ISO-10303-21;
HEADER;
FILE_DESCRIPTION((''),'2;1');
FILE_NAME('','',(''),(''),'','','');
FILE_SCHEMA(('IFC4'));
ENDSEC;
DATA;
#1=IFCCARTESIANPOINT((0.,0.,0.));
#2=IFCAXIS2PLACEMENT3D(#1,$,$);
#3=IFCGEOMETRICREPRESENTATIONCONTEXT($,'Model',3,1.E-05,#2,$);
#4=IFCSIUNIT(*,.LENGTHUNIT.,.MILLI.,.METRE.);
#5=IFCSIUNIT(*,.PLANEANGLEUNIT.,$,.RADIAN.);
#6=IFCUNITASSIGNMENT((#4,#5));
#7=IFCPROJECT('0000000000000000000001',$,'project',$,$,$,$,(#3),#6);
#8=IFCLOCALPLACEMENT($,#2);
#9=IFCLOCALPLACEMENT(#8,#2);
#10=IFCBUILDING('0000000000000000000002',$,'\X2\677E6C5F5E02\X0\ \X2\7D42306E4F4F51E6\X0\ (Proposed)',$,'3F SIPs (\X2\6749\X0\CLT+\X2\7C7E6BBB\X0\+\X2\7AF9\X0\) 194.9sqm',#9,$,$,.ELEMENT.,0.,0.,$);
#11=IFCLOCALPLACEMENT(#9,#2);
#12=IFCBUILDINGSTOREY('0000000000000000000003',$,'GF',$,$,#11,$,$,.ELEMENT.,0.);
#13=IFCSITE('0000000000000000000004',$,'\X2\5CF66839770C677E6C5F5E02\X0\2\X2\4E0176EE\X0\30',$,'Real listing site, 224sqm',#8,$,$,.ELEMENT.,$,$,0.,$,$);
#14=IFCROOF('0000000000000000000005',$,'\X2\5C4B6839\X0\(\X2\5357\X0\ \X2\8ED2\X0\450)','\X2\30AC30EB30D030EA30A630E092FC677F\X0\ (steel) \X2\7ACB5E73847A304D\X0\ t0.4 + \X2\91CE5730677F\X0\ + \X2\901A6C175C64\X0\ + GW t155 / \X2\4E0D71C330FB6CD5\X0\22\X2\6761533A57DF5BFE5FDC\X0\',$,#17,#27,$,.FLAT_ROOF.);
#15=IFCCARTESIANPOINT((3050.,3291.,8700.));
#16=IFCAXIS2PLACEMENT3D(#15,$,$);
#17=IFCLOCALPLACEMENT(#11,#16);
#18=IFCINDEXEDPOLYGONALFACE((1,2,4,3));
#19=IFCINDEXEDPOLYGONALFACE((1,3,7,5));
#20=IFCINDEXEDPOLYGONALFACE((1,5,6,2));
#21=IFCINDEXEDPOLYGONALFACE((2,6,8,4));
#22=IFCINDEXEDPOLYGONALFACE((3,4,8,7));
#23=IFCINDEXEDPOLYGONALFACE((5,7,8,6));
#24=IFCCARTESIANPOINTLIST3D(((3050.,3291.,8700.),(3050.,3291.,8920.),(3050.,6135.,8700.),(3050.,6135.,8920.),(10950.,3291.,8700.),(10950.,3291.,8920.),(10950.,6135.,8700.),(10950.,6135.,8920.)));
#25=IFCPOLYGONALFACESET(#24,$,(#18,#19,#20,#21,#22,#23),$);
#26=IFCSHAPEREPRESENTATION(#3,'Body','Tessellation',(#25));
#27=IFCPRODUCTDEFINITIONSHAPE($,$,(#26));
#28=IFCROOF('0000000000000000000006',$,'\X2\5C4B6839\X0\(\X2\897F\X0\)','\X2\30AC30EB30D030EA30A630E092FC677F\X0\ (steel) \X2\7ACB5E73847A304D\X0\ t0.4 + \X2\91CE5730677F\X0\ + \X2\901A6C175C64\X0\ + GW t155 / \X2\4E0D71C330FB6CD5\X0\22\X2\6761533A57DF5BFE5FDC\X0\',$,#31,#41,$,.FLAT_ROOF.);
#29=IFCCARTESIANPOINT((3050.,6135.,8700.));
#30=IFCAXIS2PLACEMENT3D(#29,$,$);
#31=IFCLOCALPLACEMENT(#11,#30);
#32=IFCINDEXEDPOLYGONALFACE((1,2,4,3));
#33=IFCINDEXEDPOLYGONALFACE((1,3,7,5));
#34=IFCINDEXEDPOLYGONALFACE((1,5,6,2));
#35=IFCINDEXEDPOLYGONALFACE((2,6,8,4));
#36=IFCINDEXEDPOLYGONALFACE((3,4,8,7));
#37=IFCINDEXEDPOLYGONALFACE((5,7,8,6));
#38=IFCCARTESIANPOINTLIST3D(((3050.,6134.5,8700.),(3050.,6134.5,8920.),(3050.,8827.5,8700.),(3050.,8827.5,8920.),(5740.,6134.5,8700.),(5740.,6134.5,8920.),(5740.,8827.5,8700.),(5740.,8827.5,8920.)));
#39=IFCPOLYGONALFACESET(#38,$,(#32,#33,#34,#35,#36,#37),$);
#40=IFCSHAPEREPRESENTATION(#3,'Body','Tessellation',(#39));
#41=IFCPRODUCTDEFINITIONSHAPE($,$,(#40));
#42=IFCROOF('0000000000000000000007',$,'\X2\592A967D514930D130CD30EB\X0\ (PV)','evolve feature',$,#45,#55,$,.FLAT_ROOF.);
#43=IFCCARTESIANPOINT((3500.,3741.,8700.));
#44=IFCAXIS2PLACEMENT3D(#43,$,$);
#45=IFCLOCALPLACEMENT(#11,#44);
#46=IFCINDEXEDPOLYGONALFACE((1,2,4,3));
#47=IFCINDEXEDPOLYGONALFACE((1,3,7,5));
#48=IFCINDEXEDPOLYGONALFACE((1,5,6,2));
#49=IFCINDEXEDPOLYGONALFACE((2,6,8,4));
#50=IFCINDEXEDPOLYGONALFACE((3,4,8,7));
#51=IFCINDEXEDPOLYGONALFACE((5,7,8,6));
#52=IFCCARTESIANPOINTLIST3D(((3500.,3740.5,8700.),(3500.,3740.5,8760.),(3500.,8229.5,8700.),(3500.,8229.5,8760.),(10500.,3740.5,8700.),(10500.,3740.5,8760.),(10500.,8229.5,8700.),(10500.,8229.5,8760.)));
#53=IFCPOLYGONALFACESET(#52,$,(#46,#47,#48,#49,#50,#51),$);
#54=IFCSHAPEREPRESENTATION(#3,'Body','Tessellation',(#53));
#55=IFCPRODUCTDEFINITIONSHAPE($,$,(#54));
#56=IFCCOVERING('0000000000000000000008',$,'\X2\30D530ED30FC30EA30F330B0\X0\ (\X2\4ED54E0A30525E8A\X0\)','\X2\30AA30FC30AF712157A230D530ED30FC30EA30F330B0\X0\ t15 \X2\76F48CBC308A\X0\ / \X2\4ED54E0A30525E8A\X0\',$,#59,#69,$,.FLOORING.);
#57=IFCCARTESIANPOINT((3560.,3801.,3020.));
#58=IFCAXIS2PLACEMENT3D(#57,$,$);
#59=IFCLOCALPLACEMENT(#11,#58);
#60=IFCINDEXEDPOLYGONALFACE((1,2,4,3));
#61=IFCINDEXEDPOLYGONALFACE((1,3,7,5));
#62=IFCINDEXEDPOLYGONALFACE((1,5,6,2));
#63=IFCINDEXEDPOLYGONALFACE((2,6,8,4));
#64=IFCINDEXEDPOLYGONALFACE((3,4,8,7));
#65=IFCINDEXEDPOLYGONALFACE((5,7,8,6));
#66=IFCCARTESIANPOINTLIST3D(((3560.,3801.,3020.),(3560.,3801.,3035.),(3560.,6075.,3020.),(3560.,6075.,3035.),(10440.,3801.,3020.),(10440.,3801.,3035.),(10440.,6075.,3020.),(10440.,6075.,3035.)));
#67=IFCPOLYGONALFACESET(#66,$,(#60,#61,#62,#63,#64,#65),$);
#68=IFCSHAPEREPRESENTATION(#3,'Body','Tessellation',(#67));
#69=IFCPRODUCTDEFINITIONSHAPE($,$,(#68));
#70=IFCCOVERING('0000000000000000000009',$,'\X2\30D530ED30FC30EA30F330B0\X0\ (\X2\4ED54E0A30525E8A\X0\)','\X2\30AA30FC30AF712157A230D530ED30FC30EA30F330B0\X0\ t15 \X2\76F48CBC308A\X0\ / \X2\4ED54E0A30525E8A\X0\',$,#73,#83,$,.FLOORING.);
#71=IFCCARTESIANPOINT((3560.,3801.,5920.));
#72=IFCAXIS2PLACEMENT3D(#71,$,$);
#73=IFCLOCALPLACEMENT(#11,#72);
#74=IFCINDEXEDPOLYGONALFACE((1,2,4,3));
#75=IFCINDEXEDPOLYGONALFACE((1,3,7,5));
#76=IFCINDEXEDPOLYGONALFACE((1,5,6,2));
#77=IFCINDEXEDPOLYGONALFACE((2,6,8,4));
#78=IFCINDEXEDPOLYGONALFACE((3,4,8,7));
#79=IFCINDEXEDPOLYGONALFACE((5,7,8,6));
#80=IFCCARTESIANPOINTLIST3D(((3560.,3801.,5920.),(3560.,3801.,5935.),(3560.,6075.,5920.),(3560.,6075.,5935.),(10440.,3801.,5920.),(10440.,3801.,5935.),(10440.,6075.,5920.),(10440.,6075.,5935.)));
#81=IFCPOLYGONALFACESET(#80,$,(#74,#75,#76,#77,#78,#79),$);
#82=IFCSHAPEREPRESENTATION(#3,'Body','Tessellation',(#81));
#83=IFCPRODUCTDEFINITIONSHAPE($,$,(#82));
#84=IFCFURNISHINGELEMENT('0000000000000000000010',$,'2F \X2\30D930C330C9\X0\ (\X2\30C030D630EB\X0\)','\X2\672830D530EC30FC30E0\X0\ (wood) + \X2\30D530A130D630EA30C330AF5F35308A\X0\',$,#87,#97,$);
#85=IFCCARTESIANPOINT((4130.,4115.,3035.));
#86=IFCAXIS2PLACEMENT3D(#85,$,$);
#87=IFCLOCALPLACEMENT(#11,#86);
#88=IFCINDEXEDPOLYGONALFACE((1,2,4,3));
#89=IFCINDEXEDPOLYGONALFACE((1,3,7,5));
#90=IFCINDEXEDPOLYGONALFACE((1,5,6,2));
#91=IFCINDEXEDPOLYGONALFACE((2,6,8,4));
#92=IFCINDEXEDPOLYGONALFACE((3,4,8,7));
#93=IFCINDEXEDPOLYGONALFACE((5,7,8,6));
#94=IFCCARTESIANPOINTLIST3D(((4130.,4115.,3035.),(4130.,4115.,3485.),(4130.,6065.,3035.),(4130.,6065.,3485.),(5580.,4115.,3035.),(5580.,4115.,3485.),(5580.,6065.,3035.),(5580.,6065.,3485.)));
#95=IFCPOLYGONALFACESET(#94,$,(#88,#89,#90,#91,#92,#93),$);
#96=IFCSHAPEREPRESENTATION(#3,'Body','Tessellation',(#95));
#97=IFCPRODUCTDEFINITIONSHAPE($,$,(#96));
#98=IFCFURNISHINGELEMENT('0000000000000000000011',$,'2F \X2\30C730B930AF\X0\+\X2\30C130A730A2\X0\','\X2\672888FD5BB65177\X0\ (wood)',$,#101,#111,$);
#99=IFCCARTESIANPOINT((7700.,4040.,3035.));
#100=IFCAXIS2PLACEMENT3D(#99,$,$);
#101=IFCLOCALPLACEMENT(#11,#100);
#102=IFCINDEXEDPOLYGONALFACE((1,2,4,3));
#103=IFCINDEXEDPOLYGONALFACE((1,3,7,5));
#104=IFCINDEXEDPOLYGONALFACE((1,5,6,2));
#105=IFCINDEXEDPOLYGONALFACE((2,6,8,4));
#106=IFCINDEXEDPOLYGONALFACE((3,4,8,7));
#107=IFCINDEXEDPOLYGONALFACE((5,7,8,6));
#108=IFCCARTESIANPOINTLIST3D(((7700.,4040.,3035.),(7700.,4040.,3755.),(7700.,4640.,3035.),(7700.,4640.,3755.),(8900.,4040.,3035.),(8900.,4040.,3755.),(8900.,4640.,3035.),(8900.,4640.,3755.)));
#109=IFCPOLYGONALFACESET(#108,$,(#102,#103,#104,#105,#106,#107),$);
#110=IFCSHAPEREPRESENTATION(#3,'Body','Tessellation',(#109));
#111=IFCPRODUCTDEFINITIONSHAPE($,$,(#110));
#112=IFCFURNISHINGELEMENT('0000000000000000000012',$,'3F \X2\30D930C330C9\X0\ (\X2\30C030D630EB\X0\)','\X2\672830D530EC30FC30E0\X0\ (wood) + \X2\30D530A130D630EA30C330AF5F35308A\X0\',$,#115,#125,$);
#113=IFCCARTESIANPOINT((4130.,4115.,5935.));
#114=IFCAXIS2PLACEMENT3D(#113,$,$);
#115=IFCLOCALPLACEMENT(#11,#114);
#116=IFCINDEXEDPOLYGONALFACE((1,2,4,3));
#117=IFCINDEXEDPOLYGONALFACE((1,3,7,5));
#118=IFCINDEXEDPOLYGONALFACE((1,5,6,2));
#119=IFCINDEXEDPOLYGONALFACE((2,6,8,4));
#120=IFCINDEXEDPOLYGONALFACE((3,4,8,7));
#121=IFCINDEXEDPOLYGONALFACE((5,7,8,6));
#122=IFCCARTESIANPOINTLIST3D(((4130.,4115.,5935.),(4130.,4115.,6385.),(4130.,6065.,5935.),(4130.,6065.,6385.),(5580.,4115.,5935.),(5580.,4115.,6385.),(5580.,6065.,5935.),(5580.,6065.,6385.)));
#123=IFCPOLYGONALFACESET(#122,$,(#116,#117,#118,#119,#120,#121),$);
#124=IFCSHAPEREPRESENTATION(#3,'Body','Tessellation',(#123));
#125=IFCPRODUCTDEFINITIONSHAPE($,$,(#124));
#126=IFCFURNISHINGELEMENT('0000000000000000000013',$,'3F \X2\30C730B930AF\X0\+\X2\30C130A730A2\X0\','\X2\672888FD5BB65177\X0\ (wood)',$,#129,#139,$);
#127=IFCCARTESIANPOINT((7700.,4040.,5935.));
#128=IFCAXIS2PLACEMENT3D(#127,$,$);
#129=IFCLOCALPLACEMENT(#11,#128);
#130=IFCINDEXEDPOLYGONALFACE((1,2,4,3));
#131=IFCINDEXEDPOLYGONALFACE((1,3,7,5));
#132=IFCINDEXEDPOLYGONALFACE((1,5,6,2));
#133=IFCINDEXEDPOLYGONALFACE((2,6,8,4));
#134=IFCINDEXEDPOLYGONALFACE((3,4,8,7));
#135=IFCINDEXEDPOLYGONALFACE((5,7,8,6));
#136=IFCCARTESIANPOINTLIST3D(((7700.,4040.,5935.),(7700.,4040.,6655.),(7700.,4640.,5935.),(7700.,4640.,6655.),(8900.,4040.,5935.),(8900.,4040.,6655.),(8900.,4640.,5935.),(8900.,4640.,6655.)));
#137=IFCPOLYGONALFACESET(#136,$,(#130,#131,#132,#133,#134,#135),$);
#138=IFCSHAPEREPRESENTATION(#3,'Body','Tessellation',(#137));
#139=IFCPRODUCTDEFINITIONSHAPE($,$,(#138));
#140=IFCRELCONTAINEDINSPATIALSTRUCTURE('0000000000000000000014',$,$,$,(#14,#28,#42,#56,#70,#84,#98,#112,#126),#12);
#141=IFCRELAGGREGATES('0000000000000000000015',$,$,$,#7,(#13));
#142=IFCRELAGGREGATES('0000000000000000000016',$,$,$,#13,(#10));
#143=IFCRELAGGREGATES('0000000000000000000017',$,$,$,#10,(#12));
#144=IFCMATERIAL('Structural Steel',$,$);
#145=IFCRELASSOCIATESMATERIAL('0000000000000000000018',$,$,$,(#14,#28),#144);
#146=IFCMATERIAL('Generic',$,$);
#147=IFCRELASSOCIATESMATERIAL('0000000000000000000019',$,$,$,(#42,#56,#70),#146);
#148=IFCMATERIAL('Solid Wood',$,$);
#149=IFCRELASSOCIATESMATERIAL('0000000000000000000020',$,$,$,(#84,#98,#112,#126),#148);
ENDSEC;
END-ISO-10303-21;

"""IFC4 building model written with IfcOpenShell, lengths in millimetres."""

from ifc_helpers import new_model, si_unit, frame, frame_2d, origin, place, context, project, spatial, rectangle, extrude, material, element, save


model = new_model("IFC4")

# Units and contexts
model_context = context("Model", 3, precision=1e-05, world=origin())
ifc_project = project(units=[si_unit("LENGTHUNIT", "METRE", prefix="MILLI"), si_unit("PLANEANGLEUNIT", "RADIAN")], contexts=[model_context])

# Site, building, storey
site_placement = place(None, origin())
site = spatial("IfcSite", under=ifc_project, at=site_placement, Name="島根県松江市2丁目30", ObjectType="Real listing site, 224sqm", CompositionType="ELEMENT", RefElevation=0.0)
building_placement = place(site_placement, origin())
building = spatial("IfcBuilding", under=site, at=building_placement, Name="松江市 終の住処 (Proposed)", ObjectType="3F SIPs (杉CLT+籾殻+竹) 194.9sqm", CompositionType="ELEMENT", ElevationOfRefHeight=0.0, ElevationOfTerrain=0.0)
storey_placement = place(building_placement, origin())
storey = spatial("IfcBuildingStorey", under=building, at=storey_placement, Name="GF", CompositionType="ELEMENT", Elevation=0.0)

# Shared definitions
ifc_material_1 = material(Name="Solid Wood")

# Roofs
ifc_material_2 = material(Name="Structural Steel")
roof_1_placement = place(storey_placement, frame((3050.0, 3291.0, 8700.0)))
element("IfcRoof", 1, at=roof_1_placement, inside=storey, material=ifc_material_2, Name="屋根(南 軒450)", Description="ガルバリウム鋼板 (steel) 立平葺き t0.4 + 野地板 + 通気層 + GW t155 / 不燃・法22条区域対応", PredefinedType="FLAT_ROOF", context=model_context, shape_type="SweptSolid", body=[
    extrude(rectangle(XDim=7900.0, YDim=2844.0, at=frame_2d((3950.0, 1422.0))), frame((3050.0, 3291.0, 8700.0)), (0.0, 0.0, 1.0), 220.0),
])
roof_2_placement = place(storey_placement, frame((3050.0, 6135.0, 8700.0)))
element("IfcRoof", 2, at=roof_2_placement, inside=storey, material=ifc_material_2, Name="屋根(西)", Description="ガルバリウム鋼板 (steel) 立平葺き t0.4 + 野地板 + 通気層 + GW t155 / 不燃・法22条区域対応", PredefinedType="FLAT_ROOF", context=model_context, shape_type="SweptSolid", body=[
    extrude(rectangle(XDim=2690.0, YDim=2693.0, at=frame_2d((1345.0, 1346.0))), frame((3050.0, 6135.0, 8700.0)), (0.0, 0.0, 1.0), 220.0),
])
ifc_material_3 = material(Name="Generic")
roof_3_placement = place(storey_placement, frame((3500.0, 3741.0, 8700.0)))
element("IfcRoof", 3, at=roof_3_placement, inside=storey, material=ifc_material_3, Name="太陽光パネル (PV)", Description="evolve feature", PredefinedType="FLAT_ROOF", context=model_context, shape_type="SweptSolid", body=[
    extrude(rectangle(XDim=7000.0, YDim=4489.0, at=frame_2d((3500.0, 2244.0))), frame((3500.0, 3741.0, 8700.0)), (0.0, 0.0, 1.0), 60.0),
])

# Coverings
covering_1_placement = place(storey_placement, frame((3560.0, 3801.0, 3020.0)))
element("IfcCovering", 4, at=covering_1_placement, inside=storey, material=ifc_material_3, Name="フローリング (仕上げ床)", Description="オーク無垢フローリング t15 直貼り / 仕上げ床", PredefinedType="FLOORING", context=model_context, shape_type="SweptSolid", body=[
    extrude(rectangle(XDim=6880.0, YDim=2274.0, at=frame_2d((3440.0, 1137.0))), frame((3560.0, 3801.0, 3020.0)), (0.0, 0.0, 1.0), 15.0),
])
covering_2_placement = place(storey_placement, frame((3560.0, 3801.0, 5920.0)))
element("IfcCovering", 5, at=covering_2_placement, inside=storey, material=ifc_material_3, Name="フローリング (仕上げ床)", Description="オーク無垢フローリング t15 直貼り / 仕上げ床", PredefinedType="FLOORING", context=model_context, shape_type="SweptSolid", body=[
    extrude(rectangle(XDim=6880.0, YDim=2274.0, at=frame_2d((3440.0, 1137.0))), frame((3560.0, 3801.0, 5920.0)), (0.0, 0.0, 1.0), 15.0),
])

# Furnishing elements
furnishing_1_placement = place(storey_placement, frame((4130.0, 4115.0, 3035.0)))
element("IfcFurnishingElement", 6, at=furnishing_1_placement, inside=storey, material=ifc_material_1, Name="2F ベッド (ダブル)", Description="木フレーム (wood) + ファブリック張り", context=model_context, shape_type="SweptSolid", body=[
    extrude(rectangle(XDim=1450.0, YDim=1950.0, at=frame_2d((725.0, 975.0))), frame((4130.0, 4115.0, 3035.0)), (0.0, 0.0, 1.0), 450.0),
])
furnishing_2_placement = place(storey_placement, frame((7700.0, 4040.0, 3035.0)))
element("IfcFurnishingElement", 7, at=furnishing_2_placement, inside=storey, material=ifc_material_1, Name="2F デスク+チェア", Description="木製家具 (wood)", context=model_context, shape_type="SweptSolid", body=[
    extrude(rectangle(XDim=1200.0, YDim=600.0, at=frame_2d((600.0, 300.0))), frame((7700.0, 4040.0, 3035.0)), (0.0, 0.0, 1.0), 720.0),
])
furnishing_3_placement = place(storey_placement, frame((4130.0, 4115.0, 5935.0)))
element("IfcFurnishingElement", 8, at=furnishing_3_placement, inside=storey, material=ifc_material_1, Name="3F ベッド (ダブル)", Description="木フレーム (wood) + ファブリック張り", context=model_context, shape_type="SweptSolid", body=[
    extrude(rectangle(XDim=1450.0, YDim=1950.0, at=frame_2d((725.0, 975.0))), frame((4130.0, 4115.0, 5935.0)), (0.0, 0.0, 1.0), 450.0),
])
furnishing_4_placement = place(storey_placement, frame((7700.0, 4040.0, 5935.0)))
element("IfcFurnishingElement", 9, at=furnishing_4_placement, inside=storey, material=ifc_material_1, Name="3F デスク+チェア", Description="木製家具 (wood)", context=model_context, shape_type="SweptSolid", body=[
    extrude(rectangle(XDim=1200.0, YDim=600.0, at=frame_2d((600.0, 300.0))), frame((7700.0, 4040.0, 5935.0)), (0.0, 0.0, 1.0), 720.0),
])

save(model, "model.ifc")
